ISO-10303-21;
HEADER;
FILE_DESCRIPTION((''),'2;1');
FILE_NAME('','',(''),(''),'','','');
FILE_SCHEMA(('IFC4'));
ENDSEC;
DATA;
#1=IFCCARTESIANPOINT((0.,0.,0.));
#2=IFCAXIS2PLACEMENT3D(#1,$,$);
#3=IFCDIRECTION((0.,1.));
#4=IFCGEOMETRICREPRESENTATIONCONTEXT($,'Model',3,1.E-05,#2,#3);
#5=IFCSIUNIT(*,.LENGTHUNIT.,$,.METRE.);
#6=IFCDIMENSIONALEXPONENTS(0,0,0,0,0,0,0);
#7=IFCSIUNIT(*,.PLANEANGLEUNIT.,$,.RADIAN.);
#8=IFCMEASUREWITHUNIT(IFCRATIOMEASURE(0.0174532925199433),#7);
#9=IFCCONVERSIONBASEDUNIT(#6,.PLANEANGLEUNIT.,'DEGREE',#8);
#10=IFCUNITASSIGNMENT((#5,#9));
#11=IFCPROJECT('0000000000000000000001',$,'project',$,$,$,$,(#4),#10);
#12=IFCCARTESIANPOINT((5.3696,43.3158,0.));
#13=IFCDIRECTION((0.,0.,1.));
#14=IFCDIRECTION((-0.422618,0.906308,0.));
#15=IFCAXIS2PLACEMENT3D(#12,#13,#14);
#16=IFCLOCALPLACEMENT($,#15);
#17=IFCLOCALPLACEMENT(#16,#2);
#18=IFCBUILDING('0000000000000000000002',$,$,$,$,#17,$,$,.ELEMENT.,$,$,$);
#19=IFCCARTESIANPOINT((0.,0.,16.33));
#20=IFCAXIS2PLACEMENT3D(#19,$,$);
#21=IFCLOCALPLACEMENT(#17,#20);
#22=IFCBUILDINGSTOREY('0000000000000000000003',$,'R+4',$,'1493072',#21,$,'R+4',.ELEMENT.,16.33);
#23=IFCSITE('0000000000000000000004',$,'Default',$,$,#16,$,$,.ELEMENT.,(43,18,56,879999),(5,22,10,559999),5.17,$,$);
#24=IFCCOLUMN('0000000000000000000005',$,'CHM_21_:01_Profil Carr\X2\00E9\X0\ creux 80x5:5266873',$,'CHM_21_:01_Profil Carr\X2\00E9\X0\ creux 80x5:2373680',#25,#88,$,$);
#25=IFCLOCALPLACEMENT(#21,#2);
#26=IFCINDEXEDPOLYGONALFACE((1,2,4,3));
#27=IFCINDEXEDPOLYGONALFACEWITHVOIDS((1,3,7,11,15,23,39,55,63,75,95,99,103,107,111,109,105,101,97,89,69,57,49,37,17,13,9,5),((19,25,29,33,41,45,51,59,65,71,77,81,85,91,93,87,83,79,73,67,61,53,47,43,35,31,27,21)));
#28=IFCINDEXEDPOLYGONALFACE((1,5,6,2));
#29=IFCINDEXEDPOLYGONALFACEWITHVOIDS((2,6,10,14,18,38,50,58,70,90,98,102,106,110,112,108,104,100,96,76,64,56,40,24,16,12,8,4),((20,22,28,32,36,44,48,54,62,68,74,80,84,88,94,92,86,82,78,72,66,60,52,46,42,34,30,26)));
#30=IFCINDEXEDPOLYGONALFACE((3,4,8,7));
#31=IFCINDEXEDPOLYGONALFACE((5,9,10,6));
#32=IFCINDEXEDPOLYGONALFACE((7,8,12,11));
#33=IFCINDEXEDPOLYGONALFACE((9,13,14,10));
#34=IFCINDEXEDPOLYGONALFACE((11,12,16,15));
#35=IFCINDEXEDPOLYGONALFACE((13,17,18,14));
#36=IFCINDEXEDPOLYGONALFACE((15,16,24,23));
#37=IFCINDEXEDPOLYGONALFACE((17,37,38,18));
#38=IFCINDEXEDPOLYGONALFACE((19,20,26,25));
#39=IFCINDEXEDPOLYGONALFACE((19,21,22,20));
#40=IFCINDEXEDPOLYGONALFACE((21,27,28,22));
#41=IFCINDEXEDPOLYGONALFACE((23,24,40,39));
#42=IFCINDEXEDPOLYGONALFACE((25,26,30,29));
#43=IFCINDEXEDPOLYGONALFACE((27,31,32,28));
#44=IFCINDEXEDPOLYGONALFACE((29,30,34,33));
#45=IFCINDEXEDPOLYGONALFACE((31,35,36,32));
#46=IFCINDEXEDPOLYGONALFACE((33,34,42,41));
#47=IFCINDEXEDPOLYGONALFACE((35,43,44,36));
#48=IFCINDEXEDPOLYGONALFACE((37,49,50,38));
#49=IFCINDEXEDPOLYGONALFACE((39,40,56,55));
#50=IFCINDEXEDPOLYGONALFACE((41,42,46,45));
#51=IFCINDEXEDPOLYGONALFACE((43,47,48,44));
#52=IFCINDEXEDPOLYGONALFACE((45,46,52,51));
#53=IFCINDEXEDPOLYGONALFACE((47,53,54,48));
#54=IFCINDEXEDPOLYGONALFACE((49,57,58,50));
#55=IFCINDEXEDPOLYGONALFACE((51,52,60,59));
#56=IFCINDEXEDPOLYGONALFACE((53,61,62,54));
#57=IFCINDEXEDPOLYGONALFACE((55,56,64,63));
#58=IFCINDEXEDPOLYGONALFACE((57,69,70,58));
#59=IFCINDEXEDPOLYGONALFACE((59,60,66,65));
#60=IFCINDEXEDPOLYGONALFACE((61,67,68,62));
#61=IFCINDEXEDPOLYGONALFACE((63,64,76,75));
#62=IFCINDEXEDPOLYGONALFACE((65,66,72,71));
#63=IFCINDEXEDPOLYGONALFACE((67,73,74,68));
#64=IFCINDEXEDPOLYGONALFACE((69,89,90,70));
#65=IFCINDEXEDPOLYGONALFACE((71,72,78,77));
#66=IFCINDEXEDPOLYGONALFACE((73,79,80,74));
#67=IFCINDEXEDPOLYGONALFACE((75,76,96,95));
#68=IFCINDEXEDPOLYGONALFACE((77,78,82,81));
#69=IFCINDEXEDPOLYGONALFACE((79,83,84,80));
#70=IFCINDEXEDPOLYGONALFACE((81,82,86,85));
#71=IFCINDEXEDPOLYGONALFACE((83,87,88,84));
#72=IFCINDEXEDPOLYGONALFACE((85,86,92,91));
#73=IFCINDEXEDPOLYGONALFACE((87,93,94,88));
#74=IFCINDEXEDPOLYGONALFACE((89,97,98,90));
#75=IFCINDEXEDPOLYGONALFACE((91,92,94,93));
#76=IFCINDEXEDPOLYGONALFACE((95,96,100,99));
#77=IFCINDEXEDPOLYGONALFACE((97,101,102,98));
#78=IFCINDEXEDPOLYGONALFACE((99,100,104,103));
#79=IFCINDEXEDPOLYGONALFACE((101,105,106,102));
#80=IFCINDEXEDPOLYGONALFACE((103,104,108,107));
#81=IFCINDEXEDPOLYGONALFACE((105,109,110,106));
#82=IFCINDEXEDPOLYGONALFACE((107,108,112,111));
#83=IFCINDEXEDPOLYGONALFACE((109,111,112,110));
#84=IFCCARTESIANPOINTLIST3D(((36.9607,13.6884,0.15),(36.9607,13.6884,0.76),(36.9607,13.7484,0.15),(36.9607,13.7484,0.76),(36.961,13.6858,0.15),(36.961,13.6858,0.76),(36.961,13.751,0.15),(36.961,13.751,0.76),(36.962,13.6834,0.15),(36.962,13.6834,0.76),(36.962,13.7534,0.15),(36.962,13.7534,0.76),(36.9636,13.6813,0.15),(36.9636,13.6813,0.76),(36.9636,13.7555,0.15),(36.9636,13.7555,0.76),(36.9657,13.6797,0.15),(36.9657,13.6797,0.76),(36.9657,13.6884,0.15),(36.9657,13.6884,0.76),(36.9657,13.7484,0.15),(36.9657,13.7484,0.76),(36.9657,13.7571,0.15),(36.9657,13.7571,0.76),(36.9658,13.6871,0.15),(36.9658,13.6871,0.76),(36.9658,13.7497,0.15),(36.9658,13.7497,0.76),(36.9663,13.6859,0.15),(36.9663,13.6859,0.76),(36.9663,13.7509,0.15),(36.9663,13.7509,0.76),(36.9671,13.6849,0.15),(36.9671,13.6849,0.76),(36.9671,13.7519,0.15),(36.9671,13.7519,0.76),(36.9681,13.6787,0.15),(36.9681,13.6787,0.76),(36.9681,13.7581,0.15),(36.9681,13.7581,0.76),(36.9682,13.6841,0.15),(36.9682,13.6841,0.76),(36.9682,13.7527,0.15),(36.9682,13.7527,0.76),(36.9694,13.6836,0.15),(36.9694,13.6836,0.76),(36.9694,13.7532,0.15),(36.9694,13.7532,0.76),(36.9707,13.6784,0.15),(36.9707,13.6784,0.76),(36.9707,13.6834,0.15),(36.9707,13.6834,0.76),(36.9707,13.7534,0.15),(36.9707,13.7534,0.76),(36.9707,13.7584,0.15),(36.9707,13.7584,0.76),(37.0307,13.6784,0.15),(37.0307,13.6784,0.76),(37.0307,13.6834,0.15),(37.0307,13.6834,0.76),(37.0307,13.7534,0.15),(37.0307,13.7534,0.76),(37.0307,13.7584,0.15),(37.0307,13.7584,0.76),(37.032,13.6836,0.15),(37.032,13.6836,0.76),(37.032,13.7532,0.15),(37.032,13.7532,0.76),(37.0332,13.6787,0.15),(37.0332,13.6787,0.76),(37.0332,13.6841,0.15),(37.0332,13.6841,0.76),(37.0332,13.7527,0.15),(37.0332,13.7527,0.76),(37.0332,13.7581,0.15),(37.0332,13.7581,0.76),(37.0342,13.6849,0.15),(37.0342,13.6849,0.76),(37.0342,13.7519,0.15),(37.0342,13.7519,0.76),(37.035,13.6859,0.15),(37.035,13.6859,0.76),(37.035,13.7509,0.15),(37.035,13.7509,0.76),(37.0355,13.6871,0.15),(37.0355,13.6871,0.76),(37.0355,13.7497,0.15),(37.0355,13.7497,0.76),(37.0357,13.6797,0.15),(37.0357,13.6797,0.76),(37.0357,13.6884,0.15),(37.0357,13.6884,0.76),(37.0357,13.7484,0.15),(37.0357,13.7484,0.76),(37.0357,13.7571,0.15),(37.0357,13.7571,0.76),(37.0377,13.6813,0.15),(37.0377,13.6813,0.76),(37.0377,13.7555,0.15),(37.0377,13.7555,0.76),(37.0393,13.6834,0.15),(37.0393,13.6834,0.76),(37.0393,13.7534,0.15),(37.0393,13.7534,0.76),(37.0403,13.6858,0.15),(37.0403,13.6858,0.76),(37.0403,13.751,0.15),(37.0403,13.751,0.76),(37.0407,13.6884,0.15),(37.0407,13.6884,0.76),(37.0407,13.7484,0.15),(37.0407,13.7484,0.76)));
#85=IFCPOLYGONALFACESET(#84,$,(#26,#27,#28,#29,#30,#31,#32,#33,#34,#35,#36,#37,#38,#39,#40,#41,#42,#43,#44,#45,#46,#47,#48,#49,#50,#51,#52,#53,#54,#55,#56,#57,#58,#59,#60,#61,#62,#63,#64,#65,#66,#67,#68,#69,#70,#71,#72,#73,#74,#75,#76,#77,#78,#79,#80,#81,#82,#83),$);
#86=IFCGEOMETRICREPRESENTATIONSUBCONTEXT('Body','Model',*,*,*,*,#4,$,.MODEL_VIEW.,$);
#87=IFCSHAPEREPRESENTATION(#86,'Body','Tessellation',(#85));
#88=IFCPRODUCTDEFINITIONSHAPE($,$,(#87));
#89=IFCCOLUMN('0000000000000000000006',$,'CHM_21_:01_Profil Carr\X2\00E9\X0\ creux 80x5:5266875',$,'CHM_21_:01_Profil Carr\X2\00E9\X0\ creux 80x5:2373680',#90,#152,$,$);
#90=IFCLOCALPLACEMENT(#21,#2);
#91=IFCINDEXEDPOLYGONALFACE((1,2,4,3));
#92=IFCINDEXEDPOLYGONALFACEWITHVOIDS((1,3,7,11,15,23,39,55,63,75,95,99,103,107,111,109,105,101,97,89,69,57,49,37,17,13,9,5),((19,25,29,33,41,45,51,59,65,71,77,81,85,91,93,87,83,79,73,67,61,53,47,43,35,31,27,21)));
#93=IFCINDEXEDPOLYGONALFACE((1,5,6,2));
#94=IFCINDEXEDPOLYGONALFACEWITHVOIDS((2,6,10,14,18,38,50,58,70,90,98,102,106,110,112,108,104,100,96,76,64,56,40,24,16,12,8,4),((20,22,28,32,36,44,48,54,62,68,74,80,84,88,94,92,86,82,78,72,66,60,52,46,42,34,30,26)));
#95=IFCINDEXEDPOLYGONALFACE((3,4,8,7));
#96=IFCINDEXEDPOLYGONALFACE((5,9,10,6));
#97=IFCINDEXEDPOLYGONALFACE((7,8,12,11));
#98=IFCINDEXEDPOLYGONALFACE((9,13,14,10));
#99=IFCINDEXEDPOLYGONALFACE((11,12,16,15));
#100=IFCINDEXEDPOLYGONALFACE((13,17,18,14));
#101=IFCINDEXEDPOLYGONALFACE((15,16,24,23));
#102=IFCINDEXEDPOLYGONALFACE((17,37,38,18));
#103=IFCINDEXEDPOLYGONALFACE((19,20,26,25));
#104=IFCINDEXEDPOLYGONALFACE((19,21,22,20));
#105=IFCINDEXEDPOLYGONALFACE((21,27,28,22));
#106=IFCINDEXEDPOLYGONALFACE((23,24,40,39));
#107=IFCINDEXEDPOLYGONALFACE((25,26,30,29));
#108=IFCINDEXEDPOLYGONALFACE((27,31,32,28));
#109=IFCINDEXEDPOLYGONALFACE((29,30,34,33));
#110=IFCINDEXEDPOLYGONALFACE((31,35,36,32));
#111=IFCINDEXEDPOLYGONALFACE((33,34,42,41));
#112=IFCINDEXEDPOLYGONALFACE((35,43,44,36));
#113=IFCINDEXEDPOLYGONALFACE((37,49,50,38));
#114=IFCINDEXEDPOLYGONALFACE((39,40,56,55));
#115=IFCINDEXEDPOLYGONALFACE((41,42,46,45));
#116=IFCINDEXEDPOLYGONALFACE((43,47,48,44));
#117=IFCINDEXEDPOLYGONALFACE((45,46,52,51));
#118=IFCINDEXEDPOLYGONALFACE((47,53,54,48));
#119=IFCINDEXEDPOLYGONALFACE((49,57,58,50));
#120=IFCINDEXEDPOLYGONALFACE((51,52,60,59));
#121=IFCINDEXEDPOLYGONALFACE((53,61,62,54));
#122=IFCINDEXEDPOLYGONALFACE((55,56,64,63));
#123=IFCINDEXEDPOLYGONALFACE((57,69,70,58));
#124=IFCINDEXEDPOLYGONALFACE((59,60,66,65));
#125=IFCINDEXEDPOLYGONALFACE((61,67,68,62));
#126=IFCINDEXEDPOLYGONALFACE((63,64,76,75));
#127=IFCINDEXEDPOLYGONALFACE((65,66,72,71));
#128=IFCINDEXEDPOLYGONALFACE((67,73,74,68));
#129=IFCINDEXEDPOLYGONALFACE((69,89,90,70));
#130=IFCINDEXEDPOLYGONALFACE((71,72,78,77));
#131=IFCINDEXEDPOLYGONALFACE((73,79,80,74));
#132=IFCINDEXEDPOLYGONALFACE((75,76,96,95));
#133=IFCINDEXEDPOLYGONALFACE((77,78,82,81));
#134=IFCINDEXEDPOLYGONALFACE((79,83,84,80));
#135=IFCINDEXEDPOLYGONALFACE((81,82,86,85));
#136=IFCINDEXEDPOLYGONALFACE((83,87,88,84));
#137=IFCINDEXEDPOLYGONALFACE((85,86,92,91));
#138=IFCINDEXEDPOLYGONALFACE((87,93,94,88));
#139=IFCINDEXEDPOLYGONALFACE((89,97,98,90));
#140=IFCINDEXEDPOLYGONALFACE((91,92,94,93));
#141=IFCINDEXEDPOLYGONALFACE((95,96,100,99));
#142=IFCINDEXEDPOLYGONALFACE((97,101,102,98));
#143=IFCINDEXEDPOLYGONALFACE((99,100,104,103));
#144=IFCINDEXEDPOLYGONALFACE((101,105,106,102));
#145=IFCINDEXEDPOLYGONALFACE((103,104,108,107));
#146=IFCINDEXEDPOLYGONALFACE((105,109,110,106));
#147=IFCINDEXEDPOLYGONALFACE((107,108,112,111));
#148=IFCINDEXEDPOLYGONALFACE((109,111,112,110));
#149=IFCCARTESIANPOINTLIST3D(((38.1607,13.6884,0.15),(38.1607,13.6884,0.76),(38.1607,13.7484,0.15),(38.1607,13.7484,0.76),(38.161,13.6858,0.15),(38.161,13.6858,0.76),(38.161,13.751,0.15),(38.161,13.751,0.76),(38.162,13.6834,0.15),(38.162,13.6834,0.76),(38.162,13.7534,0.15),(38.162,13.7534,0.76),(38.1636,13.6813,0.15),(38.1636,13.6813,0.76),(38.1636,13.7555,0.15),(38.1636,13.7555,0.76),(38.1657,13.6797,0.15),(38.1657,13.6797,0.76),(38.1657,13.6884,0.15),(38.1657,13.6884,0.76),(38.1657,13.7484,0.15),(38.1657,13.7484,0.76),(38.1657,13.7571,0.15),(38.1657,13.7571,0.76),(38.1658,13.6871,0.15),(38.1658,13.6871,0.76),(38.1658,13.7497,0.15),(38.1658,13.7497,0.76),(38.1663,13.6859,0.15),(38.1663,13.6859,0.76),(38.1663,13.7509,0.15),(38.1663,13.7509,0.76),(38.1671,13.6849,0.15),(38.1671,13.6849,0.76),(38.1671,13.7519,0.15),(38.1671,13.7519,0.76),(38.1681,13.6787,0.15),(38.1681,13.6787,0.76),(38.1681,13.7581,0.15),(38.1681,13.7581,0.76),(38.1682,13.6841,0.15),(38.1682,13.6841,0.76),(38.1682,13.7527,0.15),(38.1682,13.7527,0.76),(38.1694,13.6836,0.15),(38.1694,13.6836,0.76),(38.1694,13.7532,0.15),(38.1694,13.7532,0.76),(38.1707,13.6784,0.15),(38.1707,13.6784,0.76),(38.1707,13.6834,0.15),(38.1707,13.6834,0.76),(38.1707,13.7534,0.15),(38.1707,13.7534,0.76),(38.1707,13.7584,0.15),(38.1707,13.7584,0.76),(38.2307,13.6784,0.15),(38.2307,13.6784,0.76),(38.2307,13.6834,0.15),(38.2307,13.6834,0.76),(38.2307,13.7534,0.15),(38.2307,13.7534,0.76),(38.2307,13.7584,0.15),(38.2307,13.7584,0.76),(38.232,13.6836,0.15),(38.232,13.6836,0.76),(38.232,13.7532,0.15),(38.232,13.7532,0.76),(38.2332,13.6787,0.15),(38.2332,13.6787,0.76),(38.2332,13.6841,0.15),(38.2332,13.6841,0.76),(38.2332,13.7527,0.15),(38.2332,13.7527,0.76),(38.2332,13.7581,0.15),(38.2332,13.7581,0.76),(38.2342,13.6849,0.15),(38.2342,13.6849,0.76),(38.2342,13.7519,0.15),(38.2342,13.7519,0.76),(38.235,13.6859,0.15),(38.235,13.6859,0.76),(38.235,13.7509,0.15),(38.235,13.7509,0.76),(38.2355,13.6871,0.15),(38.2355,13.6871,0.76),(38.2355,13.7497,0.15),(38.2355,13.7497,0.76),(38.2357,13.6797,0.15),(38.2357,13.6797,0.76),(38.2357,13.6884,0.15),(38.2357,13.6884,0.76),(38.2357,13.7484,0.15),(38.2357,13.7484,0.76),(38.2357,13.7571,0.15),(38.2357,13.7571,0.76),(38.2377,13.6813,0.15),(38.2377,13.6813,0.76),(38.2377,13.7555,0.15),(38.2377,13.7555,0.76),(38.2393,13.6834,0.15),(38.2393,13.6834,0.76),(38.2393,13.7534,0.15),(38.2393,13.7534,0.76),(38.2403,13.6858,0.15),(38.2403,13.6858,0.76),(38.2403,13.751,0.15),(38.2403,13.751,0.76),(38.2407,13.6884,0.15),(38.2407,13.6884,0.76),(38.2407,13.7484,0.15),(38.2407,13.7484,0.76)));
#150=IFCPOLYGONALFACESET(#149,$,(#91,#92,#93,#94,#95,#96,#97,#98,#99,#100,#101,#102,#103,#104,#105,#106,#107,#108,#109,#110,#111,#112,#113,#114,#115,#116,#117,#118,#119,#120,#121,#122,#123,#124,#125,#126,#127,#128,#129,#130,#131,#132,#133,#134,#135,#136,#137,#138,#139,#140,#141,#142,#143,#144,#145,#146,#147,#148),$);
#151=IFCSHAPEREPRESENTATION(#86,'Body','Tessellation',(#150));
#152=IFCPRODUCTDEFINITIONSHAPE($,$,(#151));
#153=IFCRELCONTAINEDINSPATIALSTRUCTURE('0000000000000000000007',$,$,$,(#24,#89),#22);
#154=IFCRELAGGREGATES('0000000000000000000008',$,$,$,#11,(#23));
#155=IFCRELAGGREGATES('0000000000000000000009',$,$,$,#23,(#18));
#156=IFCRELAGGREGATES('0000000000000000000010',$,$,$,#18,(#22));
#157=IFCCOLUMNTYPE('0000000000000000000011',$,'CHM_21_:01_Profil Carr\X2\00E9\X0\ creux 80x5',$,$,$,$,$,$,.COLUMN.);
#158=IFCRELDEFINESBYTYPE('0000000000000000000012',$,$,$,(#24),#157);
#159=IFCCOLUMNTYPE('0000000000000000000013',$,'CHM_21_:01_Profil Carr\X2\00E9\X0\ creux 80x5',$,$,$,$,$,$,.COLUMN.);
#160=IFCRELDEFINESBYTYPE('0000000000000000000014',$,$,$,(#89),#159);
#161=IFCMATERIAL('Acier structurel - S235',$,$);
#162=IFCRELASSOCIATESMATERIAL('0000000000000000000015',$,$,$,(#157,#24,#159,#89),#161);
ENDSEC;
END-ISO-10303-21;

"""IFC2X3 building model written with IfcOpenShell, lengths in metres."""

from ifc_helpers import new_model, entity, si_unit, converted_unit, direction, frame, frame_2d, origin, place, context, subcontext, project, spatial, polyline, circle_curve, parameter, trimmed, segment, composite_curve, outline, extrude, source, transform, mapped, material, type_object, type_shapes, element, save


model = new_model("IFC2X3")

# Units and contexts
model_context = context("Model", 3, precision=1e-05, world=origin(), true_north=direction((0.0, 1.0)))
body_context = subcontext(model_context, "Body", "Model", "MODEL_VIEW")
ifc_project = project(units=[si_unit("LENGTHUNIT", "METRE"), converted_unit("PLANEANGLEUNIT", "DEGREE", entity("IfcRatioMeasure", 0.0174532925199433), si_unit("PLANEANGLEUNIT", "RADIAN"), dimensions=[0, 0, 0, 0, 0, 0, 0])], contexts=[model_context])

# Site, building, storey
site_placement = place(None, frame((5.3696, 43.3158, 0.0), z_axis=(0.0, 0.0, 1.0), x_axis=(-0.422618, 0.906308, 0.0)))
site = spatial("IfcSite", under=ifc_project, at=site_placement, Name="Default", CompositionType="ELEMENT", RefLatitude=(43, 18, 56, 879999), RefLongitude=(5, 22, 10, 559999), RefElevation=5.17)
building_placement = place(site_placement, origin())
building = spatial("IfcBuilding", under=site, at=building_placement, CompositionType="ELEMENT")
storey_placement = place(building_placement, frame((0.0, 0.0, 16.33)))
storey = spatial("IfcBuildingStorey", under=building, at=storey_placement, Name="R+4", ObjectType="1493072", LongName="R+4", CompositionType="ELEMENT", Elevation=16.33)

# Columns
ifc_material_1 = material(Name="Acier structurel - S235")
column_type_1 = type_object("IfcColumnType", Name="CHM_21_:01_Profil Carré creux 80x5", PredefinedType="COLUMN", material=ifc_material_1)
shared_shape_1 = source(origin(), body_context, "Body", "SweptSolid", [
    extrude(outline(composite_curve([segment(polyline([(-0.03, -0.04), (0.03, -0.04)]), True, "CONTINUOUS"), segment(trimmed(circle_curve(frame_2d((0.03, -0.03), x_axis=(-1.0, 0.0)), 0.01), [parameter(90.0)], [parameter(180.0)], True, "PARAMETER"), True, "CONTINUOUS"), segment(polyline([(0.04, -0.03), (0.04, 0.03)]), True, "CONTINUOUS"), segment(trimmed(circle_curve(frame_2d((0.03, 0.03), x_axis=(-1.0, 0.0)), 0.01), [parameter(180.0)], [parameter(270.0)], True, "PARAMETER"), True, "CONTINUOUS"), segment(polyline([(0.03, 0.04), (-0.03, 0.04)]), True, "CONTINUOUS"), segment(trimmed(circle_curve(frame_2d((-0.03, 0.03), x_axis=(-1.0, 0.0)), 0.01), [parameter(270.0)], [parameter(360.0)], True, "PARAMETER"), True, "CONTINUOUS"), segment(polyline([(-0.04, 0.03), (-0.04, -0.03)]), True, "CONTINUOUS"), segment(trimmed(circle_curve(frame_2d((-0.03, -0.03), x_axis=(-1.0, 0.0)), 0.01), [parameter(360.0)], [parameter(90.0)], True, "PARAMETER"), True, "CONTINUOUS")], self_intersect=False), holes=[composite_curve([segment(trimmed(circle_curve(frame_2d((-0.03, -0.03), x_axis=(-1.0, 0.0)), 0.005), [parameter(360.0)], [parameter(90.0)], True, "PARAMETER"), False, "CONTINUOUS"), segment(polyline([(-0.035, -0.03), (-0.035, 0.03)]), True, "CONTINUOUS"), segment(trimmed(circle_curve(frame_2d((-0.03, 0.03), x_axis=(-1.0, 0.0)), 0.005), [parameter(270.0)], [parameter(360.0)], True, "PARAMETER"), False, "CONTINUOUS"), segment(polyline([(-0.03, 0.035), (0.03, 0.035)]), True, "CONTINUOUS"), segment(trimmed(circle_curve(frame_2d((0.03, 0.03), x_axis=(-1.0, 0.0)), 0.005), [parameter(180.0)], [parameter(270.0)], True, "PARAMETER"), False, "CONTINUOUS"), segment(polyline([(0.035, 0.03), (0.035, -0.03)]), True, "CONTINUOUS"), segment(trimmed(circle_curve(frame_2d((0.03, -0.03), x_axis=(-1.0, 0.0)), 0.005), [parameter(90.0)], [parameter(180.0)], True, "PARAMETER"), False, "CONTINUOUS"), segment(polyline([(0.03, -0.035), (-0.03, -0.035)]), True, "CONTINUOUS")], self_intersect=False)]), frame((37.0007, 13.7184, 16.48), z_axis=(0.0, 0.0, 1.0), x_axis=(0.0, 1.0, 0.0)), (0.0, 0.0, 1.0), 0.61),
])
type_shapes(column_type_1, [shared_shape_1])
column_1_placement = place(storey_placement, frame((0.0, 0.0, -16.33)))
element("IfcColumn", 1, at=column_1_placement, inside=storey, type_object=column_type_1, material=ifc_material_1, Name="CHM_21_:01_Profil Carré creux 80x5:5266873", ObjectType="CHM_21_:01_Profil Carré creux 80x5:2373680", context=body_context, shape_type="MappedRepresentation", body=[
    mapped(shared_shape_1, transform((0.0, 0.0, 0.0), scale=1.0)),
])
column_type_2 = type_object("IfcColumnType", Name="CHM_21_:01_Profil Carré creux 80x5", PredefinedType="COLUMN", material=ifc_material_1)
shared_shape_2 = source(origin(), body_context, "Body", "SweptSolid", [
    extrude(outline(composite_curve([segment(polyline([(-0.03, -0.04), (0.03, -0.04)]), True, "CONTINUOUS"), segment(trimmed(circle_curve(frame_2d((0.03, -0.03), x_axis=(-1.0, 0.0)), 0.01), [parameter(90.0)], [parameter(180.0)], True, "PARAMETER"), True, "CONTINUOUS"), segment(polyline([(0.04, -0.03), (0.04, 0.03)]), True, "CONTINUOUS"), segment(trimmed(circle_curve(frame_2d((0.03, 0.03), x_axis=(-1.0, 0.0)), 0.01), [parameter(180.0)], [parameter(270.0)], True, "PARAMETER"), True, "CONTINUOUS"), segment(polyline([(0.03, 0.04), (-0.03, 0.04)]), True, "CONTINUOUS"), segment(trimmed(circle_curve(frame_2d((-0.03, 0.03), x_axis=(-1.0, 0.0)), 0.01), [parameter(270.0)], [parameter(360.0)], True, "PARAMETER"), True, "CONTINUOUS"), segment(polyline([(-0.04, 0.03), (-0.04, -0.03)]), True, "CONTINUOUS"), segment(trimmed(circle_curve(frame_2d((-0.03, -0.03), x_axis=(-1.0, 0.0)), 0.01), [parameter(360.0)], [parameter(90.0)], True, "PARAMETER"), True, "CONTINUOUS")], self_intersect=False), holes=[composite_curve([segment(trimmed(circle_curve(frame_2d((-0.03, -0.03), x_axis=(-1.0, 0.0)), 0.005), [parameter(360.0)], [parameter(90.0)], True, "PARAMETER"), False, "CONTINUOUS"), segment(polyline([(-0.035, -0.03), (-0.035, 0.03)]), True, "CONTINUOUS"), segment(trimmed(circle_curve(frame_2d((-0.03, 0.03), x_axis=(-1.0, 0.0)), 0.005), [parameter(270.0)], [parameter(360.0)], True, "PARAMETER"), False, "CONTINUOUS"), segment(polyline([(-0.03, 0.035), (0.03, 0.035)]), True, "CONTINUOUS"), segment(trimmed(circle_curve(frame_2d((0.03, 0.03), x_axis=(-1.0, 0.0)), 0.005), [parameter(180.0)], [parameter(270.0)], True, "PARAMETER"), False, "CONTINUOUS"), segment(polyline([(0.035, 0.03), (0.035, -0.03)]), True, "CONTINUOUS"), segment(trimmed(circle_curve(frame_2d((0.03, -0.03), x_axis=(-1.0, 0.0)), 0.005), [parameter(90.0)], [parameter(180.0)], True, "PARAMETER"), False, "CONTINUOUS"), segment(polyline([(0.03, -0.035), (-0.03, -0.035)]), True, "CONTINUOUS")], self_intersect=False)]), frame((38.2007, 13.7184, 16.48), z_axis=(0.0, 0.0, 1.0), x_axis=(0.0, 1.0, 0.0)), (0.0, 0.0, 1.0), 0.61),
])
type_shapes(column_type_2, [shared_shape_2])
column_2_placement = place(storey_placement, frame((0.0, 0.0, -16.33)))
element("IfcColumn", 2, at=column_2_placement, inside=storey, type_object=column_type_2, material=ifc_material_1, Name="CHM_21_:01_Profil Carré creux 80x5:5266875", ObjectType="CHM_21_:01_Profil Carré creux 80x5:2373680", context=body_context, shape_type="MappedRepresentation", body=[
    mapped(shared_shape_2, transform((0.0, 0.0, 0.0), scale=1.0)),
])

save(model, "model.ifc")
